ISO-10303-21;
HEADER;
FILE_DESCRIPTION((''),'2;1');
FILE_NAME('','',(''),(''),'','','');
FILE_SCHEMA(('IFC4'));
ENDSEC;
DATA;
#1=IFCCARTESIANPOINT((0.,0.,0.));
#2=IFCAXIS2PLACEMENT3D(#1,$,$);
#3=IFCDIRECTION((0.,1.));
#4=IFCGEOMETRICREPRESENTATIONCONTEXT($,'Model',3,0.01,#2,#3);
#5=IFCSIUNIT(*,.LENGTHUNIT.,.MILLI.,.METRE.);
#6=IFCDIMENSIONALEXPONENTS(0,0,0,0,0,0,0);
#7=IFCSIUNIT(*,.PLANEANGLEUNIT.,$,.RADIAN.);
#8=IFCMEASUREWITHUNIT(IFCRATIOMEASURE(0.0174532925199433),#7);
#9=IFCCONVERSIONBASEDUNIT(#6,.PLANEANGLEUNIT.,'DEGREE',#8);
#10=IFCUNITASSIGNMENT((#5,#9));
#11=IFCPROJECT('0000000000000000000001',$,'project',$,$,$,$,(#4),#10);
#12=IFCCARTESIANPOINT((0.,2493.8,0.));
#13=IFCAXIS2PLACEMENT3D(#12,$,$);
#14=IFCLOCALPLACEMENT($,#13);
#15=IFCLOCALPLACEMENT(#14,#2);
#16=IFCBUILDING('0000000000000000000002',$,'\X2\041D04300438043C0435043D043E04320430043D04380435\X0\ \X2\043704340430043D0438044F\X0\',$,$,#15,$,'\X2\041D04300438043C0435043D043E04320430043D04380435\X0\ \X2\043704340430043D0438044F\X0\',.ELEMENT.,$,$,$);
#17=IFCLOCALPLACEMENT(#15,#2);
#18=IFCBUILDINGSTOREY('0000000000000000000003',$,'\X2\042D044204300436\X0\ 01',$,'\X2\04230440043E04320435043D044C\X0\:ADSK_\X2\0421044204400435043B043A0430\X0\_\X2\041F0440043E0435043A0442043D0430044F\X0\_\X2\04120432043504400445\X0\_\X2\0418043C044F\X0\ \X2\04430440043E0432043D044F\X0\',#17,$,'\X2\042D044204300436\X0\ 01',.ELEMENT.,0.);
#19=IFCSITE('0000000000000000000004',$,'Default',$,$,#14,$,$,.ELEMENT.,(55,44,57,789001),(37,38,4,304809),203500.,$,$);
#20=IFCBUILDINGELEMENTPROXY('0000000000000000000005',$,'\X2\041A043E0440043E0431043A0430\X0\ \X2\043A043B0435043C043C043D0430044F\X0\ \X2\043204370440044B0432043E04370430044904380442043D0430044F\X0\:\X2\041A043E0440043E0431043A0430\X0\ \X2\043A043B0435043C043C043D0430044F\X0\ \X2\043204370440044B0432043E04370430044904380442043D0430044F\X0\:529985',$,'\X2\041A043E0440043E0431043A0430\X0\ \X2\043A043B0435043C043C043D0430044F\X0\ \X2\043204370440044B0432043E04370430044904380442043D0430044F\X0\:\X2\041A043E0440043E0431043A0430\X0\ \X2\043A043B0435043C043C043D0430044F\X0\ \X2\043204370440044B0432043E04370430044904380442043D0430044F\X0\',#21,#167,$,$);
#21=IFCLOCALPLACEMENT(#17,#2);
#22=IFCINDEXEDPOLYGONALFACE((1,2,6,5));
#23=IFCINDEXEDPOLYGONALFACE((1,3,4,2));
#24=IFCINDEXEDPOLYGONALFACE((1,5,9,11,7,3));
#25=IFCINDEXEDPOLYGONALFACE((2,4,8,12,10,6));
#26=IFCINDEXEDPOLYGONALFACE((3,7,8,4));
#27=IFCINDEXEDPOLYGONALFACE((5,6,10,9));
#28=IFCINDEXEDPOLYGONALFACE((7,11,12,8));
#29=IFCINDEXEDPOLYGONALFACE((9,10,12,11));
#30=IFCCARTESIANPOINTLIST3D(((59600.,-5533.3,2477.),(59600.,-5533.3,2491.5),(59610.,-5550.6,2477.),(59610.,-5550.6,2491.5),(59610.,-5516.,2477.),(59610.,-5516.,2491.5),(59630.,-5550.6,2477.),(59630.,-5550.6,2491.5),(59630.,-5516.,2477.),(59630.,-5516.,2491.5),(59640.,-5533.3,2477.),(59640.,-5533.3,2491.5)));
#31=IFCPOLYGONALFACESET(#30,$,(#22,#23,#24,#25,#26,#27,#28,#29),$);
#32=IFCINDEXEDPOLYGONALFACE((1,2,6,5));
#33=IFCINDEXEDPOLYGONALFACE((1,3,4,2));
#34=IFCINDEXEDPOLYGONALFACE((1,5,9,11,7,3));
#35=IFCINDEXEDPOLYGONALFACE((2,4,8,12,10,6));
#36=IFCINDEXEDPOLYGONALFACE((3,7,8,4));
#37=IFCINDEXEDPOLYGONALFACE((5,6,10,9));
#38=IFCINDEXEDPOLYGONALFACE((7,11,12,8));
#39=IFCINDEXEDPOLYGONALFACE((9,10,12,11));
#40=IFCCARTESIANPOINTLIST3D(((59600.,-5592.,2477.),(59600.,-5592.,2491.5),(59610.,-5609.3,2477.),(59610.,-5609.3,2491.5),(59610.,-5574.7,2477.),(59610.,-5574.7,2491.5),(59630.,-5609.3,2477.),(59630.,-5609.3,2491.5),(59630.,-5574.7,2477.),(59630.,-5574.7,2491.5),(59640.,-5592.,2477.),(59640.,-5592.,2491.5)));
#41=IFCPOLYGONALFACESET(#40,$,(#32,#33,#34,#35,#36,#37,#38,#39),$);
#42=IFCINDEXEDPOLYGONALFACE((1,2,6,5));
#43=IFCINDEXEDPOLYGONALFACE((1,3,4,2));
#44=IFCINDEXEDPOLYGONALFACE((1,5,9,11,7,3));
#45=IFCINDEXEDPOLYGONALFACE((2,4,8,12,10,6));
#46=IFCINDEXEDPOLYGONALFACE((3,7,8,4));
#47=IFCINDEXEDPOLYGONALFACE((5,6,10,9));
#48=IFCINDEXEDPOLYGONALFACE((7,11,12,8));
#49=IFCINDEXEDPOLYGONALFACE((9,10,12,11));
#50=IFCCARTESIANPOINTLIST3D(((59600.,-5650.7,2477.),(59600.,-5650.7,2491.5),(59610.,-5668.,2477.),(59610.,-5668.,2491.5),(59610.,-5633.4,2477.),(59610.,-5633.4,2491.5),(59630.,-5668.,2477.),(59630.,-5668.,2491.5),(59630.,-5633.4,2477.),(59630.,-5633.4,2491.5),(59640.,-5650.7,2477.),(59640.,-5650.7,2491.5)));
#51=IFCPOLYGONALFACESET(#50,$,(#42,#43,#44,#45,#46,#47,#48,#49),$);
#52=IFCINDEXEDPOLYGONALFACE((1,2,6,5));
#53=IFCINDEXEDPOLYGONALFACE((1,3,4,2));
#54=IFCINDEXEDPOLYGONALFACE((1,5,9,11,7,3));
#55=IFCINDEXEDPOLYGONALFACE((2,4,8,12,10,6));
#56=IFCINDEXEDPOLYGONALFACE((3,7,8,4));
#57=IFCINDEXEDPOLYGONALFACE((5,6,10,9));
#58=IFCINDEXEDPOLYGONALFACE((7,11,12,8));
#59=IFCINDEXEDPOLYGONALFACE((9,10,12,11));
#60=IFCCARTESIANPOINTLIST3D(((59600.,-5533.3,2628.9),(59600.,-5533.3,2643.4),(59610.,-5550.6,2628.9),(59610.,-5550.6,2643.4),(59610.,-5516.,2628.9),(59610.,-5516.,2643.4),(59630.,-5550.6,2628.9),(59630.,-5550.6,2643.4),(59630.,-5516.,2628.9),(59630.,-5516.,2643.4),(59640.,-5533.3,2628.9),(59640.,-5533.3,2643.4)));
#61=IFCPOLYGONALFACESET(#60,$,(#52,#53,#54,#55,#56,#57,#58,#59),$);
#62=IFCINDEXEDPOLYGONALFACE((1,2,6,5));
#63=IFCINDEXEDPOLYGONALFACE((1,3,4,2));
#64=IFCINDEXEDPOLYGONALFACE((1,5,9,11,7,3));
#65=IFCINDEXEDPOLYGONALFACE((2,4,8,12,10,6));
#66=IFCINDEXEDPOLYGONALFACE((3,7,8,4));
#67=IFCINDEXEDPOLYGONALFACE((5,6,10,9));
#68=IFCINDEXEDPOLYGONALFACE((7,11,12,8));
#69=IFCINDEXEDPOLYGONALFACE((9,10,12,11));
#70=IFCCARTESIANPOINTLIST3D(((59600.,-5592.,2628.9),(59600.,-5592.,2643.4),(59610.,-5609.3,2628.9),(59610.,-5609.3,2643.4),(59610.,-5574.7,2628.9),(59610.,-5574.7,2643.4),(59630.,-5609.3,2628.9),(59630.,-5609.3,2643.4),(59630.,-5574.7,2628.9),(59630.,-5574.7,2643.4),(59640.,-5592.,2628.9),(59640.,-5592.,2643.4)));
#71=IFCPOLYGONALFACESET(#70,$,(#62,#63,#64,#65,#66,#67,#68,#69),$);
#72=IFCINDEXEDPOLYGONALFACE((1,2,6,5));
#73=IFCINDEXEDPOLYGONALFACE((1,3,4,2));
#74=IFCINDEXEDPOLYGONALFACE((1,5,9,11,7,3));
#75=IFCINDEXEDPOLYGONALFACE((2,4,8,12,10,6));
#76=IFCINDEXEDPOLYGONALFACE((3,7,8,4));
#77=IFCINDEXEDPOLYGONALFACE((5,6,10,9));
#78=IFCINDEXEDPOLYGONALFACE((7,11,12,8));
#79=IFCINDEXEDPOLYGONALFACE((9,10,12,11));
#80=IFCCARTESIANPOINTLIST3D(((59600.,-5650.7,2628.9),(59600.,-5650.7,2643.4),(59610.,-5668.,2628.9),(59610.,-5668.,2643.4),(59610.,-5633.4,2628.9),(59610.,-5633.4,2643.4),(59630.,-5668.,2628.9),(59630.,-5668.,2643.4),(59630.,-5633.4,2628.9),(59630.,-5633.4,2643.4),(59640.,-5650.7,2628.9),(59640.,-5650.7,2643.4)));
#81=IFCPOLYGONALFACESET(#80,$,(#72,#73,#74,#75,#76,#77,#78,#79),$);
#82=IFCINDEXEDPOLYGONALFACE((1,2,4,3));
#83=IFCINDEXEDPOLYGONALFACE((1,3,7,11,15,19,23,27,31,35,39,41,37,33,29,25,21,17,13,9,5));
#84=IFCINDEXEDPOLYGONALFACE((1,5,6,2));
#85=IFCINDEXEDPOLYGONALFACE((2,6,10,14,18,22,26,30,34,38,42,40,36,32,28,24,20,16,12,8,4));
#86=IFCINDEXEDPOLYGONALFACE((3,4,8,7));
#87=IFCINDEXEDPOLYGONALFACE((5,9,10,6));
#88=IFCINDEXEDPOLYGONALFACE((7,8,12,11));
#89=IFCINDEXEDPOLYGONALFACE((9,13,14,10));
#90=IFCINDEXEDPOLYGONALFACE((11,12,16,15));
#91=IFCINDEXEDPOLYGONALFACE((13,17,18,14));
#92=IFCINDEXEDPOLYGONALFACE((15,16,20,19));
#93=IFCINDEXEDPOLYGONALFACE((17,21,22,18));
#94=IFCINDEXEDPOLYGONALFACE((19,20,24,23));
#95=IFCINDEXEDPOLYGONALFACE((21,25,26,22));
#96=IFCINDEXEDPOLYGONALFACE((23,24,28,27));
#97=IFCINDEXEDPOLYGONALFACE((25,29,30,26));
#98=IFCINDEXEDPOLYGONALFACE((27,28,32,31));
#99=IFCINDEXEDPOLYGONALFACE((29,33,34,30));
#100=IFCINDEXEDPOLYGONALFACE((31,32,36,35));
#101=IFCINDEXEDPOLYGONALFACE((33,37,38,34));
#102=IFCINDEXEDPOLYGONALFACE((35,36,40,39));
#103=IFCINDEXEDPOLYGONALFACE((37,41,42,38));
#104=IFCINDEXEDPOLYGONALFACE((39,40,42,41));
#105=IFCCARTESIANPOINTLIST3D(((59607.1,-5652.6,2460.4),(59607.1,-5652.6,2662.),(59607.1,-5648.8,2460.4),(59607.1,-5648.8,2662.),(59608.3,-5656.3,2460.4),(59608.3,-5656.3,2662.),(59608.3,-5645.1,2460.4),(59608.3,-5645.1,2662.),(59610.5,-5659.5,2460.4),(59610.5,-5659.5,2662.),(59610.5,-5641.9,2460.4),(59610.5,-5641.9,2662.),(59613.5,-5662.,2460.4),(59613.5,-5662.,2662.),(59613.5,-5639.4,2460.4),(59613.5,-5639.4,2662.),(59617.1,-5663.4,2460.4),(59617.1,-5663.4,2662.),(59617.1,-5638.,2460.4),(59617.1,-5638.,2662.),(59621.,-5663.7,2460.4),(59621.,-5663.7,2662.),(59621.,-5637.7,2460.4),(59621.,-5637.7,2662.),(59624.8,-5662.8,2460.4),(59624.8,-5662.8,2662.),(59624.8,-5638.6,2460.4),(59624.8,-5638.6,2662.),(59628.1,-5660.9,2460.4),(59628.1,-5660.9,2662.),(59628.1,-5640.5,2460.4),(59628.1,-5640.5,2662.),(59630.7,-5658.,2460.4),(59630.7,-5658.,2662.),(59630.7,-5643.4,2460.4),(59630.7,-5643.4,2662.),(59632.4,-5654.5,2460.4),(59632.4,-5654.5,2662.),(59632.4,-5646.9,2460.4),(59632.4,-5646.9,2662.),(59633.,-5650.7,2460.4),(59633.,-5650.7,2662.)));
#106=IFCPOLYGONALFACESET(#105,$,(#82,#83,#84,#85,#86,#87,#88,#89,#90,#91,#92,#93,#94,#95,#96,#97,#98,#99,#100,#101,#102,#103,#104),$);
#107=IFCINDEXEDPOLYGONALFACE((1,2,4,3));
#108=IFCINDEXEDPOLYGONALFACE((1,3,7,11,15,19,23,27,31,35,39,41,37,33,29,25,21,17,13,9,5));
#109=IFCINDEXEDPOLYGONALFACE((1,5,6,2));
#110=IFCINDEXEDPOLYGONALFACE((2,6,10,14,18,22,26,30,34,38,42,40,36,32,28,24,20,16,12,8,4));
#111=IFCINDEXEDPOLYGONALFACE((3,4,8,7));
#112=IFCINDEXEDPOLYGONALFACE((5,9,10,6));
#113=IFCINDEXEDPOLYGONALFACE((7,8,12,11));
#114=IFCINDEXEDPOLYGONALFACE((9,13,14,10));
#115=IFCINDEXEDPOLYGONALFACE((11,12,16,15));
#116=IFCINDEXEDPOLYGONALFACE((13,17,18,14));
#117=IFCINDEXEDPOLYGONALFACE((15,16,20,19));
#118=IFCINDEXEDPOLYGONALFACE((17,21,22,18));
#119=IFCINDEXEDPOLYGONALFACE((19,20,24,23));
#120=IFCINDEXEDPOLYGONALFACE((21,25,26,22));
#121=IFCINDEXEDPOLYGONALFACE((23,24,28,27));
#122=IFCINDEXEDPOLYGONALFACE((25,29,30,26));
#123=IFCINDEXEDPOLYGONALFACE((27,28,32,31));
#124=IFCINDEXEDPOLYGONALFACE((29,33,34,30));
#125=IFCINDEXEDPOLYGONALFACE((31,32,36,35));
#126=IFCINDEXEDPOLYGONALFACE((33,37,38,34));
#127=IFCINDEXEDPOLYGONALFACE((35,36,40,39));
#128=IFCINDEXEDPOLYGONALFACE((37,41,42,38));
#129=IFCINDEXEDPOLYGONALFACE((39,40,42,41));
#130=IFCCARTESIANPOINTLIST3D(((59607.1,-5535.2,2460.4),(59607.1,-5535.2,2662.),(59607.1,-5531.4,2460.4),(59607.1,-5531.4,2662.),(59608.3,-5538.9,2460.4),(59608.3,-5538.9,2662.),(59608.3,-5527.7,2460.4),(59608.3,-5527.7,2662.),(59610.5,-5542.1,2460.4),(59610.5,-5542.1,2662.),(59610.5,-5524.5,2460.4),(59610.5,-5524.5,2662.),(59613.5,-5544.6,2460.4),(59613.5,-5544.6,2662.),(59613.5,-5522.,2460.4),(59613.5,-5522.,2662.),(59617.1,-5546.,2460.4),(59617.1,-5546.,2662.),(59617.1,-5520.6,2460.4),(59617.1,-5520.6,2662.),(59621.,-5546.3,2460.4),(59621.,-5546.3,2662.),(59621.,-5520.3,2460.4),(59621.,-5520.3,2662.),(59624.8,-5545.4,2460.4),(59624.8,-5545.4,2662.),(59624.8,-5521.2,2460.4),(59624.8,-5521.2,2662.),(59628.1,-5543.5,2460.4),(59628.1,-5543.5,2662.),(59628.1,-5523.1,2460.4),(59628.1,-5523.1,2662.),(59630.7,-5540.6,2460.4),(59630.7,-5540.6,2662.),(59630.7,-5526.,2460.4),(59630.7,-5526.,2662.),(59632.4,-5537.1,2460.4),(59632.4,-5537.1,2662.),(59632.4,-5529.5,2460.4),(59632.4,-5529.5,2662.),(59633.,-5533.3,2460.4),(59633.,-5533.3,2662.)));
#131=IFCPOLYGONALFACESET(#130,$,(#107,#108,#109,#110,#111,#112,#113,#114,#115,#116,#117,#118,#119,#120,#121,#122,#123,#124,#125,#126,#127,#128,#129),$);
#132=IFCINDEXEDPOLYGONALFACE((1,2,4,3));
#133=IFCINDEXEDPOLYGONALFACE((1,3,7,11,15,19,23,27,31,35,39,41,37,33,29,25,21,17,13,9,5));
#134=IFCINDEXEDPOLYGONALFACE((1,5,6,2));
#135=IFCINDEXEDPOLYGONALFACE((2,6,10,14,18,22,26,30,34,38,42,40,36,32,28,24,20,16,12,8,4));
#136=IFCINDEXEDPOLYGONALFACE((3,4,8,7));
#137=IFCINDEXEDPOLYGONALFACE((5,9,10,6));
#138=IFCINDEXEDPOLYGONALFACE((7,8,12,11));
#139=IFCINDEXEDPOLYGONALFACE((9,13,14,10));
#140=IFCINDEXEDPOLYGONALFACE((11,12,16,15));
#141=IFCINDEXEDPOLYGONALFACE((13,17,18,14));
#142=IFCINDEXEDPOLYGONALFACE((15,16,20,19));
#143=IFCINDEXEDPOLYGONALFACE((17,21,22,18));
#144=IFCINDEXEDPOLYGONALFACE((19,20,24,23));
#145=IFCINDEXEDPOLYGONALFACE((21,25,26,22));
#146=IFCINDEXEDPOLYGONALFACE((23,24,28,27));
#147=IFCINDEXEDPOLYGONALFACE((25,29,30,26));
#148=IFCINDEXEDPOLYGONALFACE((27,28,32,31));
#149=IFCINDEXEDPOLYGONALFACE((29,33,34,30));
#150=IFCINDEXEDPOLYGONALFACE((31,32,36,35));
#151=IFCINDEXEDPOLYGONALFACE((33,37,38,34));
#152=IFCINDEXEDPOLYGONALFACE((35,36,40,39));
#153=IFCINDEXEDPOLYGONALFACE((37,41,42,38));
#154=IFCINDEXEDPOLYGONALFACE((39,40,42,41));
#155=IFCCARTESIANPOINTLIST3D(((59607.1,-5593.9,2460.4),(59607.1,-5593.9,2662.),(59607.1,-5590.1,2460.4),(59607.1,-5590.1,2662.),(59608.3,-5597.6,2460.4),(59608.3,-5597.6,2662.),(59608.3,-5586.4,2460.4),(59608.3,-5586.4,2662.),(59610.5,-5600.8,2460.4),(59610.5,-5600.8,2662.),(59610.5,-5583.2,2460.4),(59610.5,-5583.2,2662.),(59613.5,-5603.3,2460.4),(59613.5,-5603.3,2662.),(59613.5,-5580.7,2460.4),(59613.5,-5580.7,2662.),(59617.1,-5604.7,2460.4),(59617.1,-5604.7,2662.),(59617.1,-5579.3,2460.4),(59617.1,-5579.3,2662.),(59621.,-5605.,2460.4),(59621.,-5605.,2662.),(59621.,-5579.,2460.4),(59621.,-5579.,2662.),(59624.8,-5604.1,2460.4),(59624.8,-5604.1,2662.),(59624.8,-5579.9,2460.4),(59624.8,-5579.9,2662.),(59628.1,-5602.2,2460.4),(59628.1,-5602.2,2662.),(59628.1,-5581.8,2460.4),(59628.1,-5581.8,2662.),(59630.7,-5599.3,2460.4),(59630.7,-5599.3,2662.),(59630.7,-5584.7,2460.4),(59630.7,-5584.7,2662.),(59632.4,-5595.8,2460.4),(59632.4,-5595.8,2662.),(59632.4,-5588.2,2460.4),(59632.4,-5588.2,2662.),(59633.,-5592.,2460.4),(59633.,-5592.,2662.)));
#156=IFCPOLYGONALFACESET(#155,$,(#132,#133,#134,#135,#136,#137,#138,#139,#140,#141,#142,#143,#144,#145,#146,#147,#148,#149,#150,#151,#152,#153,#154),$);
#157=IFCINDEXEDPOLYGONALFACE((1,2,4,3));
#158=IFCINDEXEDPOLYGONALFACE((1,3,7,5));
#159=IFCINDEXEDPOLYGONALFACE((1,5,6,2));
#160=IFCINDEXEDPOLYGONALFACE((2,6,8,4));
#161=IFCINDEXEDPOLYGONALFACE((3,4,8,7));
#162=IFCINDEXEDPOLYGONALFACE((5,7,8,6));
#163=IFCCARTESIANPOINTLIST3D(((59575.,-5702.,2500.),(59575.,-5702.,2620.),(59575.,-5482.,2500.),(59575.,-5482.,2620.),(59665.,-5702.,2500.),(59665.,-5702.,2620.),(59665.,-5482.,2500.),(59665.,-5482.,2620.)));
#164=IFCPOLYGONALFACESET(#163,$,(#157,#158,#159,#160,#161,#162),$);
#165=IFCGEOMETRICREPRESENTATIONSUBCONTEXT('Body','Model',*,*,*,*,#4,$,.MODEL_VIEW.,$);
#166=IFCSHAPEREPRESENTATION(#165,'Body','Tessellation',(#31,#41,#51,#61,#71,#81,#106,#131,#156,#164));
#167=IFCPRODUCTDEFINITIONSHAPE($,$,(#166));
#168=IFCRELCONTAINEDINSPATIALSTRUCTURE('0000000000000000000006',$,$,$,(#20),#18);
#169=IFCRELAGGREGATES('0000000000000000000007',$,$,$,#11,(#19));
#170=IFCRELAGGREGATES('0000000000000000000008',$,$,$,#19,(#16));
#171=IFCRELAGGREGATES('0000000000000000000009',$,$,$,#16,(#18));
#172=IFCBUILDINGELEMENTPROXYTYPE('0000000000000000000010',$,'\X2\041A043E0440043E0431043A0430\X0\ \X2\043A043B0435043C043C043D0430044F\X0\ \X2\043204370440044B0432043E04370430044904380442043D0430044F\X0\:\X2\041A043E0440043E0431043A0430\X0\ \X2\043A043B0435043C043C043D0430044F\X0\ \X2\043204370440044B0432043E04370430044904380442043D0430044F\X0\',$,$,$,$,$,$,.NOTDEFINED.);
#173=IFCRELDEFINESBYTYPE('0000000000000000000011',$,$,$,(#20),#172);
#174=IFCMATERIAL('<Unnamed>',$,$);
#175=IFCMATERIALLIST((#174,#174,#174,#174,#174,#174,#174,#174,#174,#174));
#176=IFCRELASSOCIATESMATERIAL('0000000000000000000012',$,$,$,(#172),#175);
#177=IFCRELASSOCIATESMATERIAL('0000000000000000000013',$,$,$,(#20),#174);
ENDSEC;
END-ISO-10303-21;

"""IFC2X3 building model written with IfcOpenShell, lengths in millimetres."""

from ifc_helpers import new_model, entity, si_unit, converted_unit, direction, frame, frame_2d, origin, place, context, subcontext, project, spatial, polyline, rectangle, circle, outline, extrude, source, transform, mapped, material, material_list, type_object, type_shapes, element, save


model = new_model("IFC2X3")

# Units and contexts
model_context = context("Model", 3, precision=0.01, world=origin(), true_north=direction((0.0, 1.0)))
body_context = subcontext(model_context, "Body", "Model", "MODEL_VIEW")
ifc_project = project(units=[si_unit("LENGTHUNIT", "METRE", prefix="MILLI"), converted_unit("PLANEANGLEUNIT", "DEGREE", entity("IfcRatioMeasure", 0.0174532925199433), si_unit("PLANEANGLEUNIT", "RADIAN"), dimensions=[0, 0, 0, 0, 0, 0, 0])], contexts=[model_context])

# Site, building, storey
site_placement = place(None, frame((0.0, 2493.8, 0.0)))
site = spatial("IfcSite", under=ifc_project, at=site_placement, Name="Default", CompositionType="ELEMENT", RefLatitude=(55, 44, 57, 789001), RefLongitude=(37, 38, 4, 304809), RefElevation=203500.0)
building_placement = place(site_placement, origin())
building = spatial("IfcBuilding", under=site, at=building_placement, Name="Наименование здания", LongName="Наименование здания", CompositionType="ELEMENT")
storey_placement = place(building_placement, origin())
storey = spatial("IfcBuildingStorey", under=building, at=storey_placement, Name="Этаж 01", ObjectType="Уровень:ADSK_Стрелка_Проектная_Вверх_Имя уровня", LongName="Этаж 01", CompositionType="ELEMENT", Elevation=0.0)

# Building element proxy
ifc_material_1 = material(Name="<Unnamed>")
ifc_material_list_1 = material_list([ifc_material_1, ifc_material_1, ifc_material_1, ifc_material_1, ifc_material_1, ifc_material_1, ifc_material_1, ifc_material_1, ifc_material_1, ifc_material_1])
building_element_proxy_type_1 = type_object("IfcBuildingElementProxyType", Name="Коробка клеммная взрывозащитная:Коробка клеммная взрывозащитная", PredefinedType="NOTDEFINED", material=ifc_material_list_1)
shared_shape_1 = source(origin(), body_context, "Body", "SweptSolid", [
    extrude(outline(polyline([(-10.0, -17.3), (10.0, -17.3), (20.0, 0.0), (10.0, 17.3), (-10.0, 17.3), (-20.0, 0.0), (-10.0, -17.3)])), frame((0.0, 58.7, -23.0), z_axis=(0.0, 0.0, 1.0), x_axis=(-1.0, 0.0, 0.0)), (0.0, 0.0, 1.0), 14.4),
    extrude(outline(polyline([(-10.0, -17.3), (10.0, -17.3), (20.0, 0.0), (10.0, 17.3), (-10.0, 17.3), (-20.0, 0.0), (-10.0, -17.3)])), frame((0.0, 0.0, -23.0), z_axis=(0.0, 0.0, 1.0), x_axis=(-1.0, 0.0, 0.0)), (0.0, 0.0, 1.0), 14.4),
    extrude(outline(polyline([(-10.0, -17.3), (10.0, -17.3), (20.0, 0.0), (10.0, 17.3), (-10.0, 17.3), (-20.0, 0.0), (-10.0, -17.3)])), frame((0.0, -58.7, -23.0), z_axis=(0.0, 0.0, 1.0), x_axis=(-1.0, 0.0, 0.0)), (0.0, 0.0, 1.0), 14.4),
    extrude(outline(polyline([(-10.0, -17.3), (10.0, -17.3), (20.0, 0.0), (10.0, 17.3), (-10.0, 17.3), (-20.0, 0.0), (-10.0, -17.3)])), frame((0.0, 58.7, 128.9), z_axis=(0.0, 0.0, 1.0), x_axis=(-1.0, 0.0, 0.0)), (0.0, 0.0, 1.0), 14.4),
    extrude(outline(polyline([(-10.0, -17.3), (10.0, -17.3), (20.0, 0.0), (10.0, 17.3), (-10.0, 17.3), (-20.0, 0.0), (-10.0, -17.3)])), frame((0.0, 0.0, 128.9), z_axis=(0.0, 0.0, 1.0), x_axis=(-1.0, 0.0, 0.0)), (0.0, 0.0, 1.0), 14.4),
    extrude(outline(polyline([(-10.0, -17.3), (10.0, -17.3), (20.0, 0.0), (10.0, 17.3), (-10.0, 17.3), (-20.0, 0.0), (-10.0, -17.3)])), frame((0.0, -58.7, 128.9), z_axis=(0.0, 0.0, 1.0), x_axis=(-1.0, 0.0, 0.0)), (0.0, 0.0, 1.0), 14.4),
    extrude(circle(Radius=13.0, at=frame_2d((0.0, 0.0), x_axis=(1.0, 0.0))), frame((0.0, -58.7, -39.6)), (0.0, 0.0, 1.0), 201.6),
    extrude(circle(Radius=13.0, at=frame_2d((0.0, 0.0), x_axis=(1.0, 0.0))), frame((0.0, 58.7, -39.6)), (0.0, 0.0, 1.0), 201.6),
    extrude(circle(Radius=13.0, at=frame_2d((0.0, 0.0), x_axis=(1.0, 0.0))), frame((0.0, 0.0, -39.6)), (0.0, 0.0, 1.0), 201.6),
    extrude(rectangle(XDim=220.0, YDim=90.0, at=frame_2d((0.0, 0.0), x_axis=(1.0, 0.0))), frame((0.0, 0.0, 0.0), z_axis=(0.0, 0.0, 1.0), x_axis=(0.0, -1.0, 0.0)), (0.0, 0.0, 1.0), 120.0),
])
type_shapes(building_element_proxy_type_1, [shared_shape_1])
for number, where, name in (
    (1, (59620.0, -5592.0, 2500.0), "Коробка клеммная взрывозащитная:Коробка клеммная взрывозащитная:529985"),
):
    element("IfcBuildingElementProxy", number, at=place(storey_placement, frame(where)), inside=storey, type_object=building_element_proxy_type_1, material=ifc_material_1, Name=name, ObjectType="Коробка клеммная взрывозащитная:Коробка клеммная взрывозащитная", context=body_context, shape_type="MappedRepresentation", body=[
        mapped(shared_shape_1, transform((0.0, 0.0, 0.0), scale=1.0)),
    ])

save(model, "model.ifc")
